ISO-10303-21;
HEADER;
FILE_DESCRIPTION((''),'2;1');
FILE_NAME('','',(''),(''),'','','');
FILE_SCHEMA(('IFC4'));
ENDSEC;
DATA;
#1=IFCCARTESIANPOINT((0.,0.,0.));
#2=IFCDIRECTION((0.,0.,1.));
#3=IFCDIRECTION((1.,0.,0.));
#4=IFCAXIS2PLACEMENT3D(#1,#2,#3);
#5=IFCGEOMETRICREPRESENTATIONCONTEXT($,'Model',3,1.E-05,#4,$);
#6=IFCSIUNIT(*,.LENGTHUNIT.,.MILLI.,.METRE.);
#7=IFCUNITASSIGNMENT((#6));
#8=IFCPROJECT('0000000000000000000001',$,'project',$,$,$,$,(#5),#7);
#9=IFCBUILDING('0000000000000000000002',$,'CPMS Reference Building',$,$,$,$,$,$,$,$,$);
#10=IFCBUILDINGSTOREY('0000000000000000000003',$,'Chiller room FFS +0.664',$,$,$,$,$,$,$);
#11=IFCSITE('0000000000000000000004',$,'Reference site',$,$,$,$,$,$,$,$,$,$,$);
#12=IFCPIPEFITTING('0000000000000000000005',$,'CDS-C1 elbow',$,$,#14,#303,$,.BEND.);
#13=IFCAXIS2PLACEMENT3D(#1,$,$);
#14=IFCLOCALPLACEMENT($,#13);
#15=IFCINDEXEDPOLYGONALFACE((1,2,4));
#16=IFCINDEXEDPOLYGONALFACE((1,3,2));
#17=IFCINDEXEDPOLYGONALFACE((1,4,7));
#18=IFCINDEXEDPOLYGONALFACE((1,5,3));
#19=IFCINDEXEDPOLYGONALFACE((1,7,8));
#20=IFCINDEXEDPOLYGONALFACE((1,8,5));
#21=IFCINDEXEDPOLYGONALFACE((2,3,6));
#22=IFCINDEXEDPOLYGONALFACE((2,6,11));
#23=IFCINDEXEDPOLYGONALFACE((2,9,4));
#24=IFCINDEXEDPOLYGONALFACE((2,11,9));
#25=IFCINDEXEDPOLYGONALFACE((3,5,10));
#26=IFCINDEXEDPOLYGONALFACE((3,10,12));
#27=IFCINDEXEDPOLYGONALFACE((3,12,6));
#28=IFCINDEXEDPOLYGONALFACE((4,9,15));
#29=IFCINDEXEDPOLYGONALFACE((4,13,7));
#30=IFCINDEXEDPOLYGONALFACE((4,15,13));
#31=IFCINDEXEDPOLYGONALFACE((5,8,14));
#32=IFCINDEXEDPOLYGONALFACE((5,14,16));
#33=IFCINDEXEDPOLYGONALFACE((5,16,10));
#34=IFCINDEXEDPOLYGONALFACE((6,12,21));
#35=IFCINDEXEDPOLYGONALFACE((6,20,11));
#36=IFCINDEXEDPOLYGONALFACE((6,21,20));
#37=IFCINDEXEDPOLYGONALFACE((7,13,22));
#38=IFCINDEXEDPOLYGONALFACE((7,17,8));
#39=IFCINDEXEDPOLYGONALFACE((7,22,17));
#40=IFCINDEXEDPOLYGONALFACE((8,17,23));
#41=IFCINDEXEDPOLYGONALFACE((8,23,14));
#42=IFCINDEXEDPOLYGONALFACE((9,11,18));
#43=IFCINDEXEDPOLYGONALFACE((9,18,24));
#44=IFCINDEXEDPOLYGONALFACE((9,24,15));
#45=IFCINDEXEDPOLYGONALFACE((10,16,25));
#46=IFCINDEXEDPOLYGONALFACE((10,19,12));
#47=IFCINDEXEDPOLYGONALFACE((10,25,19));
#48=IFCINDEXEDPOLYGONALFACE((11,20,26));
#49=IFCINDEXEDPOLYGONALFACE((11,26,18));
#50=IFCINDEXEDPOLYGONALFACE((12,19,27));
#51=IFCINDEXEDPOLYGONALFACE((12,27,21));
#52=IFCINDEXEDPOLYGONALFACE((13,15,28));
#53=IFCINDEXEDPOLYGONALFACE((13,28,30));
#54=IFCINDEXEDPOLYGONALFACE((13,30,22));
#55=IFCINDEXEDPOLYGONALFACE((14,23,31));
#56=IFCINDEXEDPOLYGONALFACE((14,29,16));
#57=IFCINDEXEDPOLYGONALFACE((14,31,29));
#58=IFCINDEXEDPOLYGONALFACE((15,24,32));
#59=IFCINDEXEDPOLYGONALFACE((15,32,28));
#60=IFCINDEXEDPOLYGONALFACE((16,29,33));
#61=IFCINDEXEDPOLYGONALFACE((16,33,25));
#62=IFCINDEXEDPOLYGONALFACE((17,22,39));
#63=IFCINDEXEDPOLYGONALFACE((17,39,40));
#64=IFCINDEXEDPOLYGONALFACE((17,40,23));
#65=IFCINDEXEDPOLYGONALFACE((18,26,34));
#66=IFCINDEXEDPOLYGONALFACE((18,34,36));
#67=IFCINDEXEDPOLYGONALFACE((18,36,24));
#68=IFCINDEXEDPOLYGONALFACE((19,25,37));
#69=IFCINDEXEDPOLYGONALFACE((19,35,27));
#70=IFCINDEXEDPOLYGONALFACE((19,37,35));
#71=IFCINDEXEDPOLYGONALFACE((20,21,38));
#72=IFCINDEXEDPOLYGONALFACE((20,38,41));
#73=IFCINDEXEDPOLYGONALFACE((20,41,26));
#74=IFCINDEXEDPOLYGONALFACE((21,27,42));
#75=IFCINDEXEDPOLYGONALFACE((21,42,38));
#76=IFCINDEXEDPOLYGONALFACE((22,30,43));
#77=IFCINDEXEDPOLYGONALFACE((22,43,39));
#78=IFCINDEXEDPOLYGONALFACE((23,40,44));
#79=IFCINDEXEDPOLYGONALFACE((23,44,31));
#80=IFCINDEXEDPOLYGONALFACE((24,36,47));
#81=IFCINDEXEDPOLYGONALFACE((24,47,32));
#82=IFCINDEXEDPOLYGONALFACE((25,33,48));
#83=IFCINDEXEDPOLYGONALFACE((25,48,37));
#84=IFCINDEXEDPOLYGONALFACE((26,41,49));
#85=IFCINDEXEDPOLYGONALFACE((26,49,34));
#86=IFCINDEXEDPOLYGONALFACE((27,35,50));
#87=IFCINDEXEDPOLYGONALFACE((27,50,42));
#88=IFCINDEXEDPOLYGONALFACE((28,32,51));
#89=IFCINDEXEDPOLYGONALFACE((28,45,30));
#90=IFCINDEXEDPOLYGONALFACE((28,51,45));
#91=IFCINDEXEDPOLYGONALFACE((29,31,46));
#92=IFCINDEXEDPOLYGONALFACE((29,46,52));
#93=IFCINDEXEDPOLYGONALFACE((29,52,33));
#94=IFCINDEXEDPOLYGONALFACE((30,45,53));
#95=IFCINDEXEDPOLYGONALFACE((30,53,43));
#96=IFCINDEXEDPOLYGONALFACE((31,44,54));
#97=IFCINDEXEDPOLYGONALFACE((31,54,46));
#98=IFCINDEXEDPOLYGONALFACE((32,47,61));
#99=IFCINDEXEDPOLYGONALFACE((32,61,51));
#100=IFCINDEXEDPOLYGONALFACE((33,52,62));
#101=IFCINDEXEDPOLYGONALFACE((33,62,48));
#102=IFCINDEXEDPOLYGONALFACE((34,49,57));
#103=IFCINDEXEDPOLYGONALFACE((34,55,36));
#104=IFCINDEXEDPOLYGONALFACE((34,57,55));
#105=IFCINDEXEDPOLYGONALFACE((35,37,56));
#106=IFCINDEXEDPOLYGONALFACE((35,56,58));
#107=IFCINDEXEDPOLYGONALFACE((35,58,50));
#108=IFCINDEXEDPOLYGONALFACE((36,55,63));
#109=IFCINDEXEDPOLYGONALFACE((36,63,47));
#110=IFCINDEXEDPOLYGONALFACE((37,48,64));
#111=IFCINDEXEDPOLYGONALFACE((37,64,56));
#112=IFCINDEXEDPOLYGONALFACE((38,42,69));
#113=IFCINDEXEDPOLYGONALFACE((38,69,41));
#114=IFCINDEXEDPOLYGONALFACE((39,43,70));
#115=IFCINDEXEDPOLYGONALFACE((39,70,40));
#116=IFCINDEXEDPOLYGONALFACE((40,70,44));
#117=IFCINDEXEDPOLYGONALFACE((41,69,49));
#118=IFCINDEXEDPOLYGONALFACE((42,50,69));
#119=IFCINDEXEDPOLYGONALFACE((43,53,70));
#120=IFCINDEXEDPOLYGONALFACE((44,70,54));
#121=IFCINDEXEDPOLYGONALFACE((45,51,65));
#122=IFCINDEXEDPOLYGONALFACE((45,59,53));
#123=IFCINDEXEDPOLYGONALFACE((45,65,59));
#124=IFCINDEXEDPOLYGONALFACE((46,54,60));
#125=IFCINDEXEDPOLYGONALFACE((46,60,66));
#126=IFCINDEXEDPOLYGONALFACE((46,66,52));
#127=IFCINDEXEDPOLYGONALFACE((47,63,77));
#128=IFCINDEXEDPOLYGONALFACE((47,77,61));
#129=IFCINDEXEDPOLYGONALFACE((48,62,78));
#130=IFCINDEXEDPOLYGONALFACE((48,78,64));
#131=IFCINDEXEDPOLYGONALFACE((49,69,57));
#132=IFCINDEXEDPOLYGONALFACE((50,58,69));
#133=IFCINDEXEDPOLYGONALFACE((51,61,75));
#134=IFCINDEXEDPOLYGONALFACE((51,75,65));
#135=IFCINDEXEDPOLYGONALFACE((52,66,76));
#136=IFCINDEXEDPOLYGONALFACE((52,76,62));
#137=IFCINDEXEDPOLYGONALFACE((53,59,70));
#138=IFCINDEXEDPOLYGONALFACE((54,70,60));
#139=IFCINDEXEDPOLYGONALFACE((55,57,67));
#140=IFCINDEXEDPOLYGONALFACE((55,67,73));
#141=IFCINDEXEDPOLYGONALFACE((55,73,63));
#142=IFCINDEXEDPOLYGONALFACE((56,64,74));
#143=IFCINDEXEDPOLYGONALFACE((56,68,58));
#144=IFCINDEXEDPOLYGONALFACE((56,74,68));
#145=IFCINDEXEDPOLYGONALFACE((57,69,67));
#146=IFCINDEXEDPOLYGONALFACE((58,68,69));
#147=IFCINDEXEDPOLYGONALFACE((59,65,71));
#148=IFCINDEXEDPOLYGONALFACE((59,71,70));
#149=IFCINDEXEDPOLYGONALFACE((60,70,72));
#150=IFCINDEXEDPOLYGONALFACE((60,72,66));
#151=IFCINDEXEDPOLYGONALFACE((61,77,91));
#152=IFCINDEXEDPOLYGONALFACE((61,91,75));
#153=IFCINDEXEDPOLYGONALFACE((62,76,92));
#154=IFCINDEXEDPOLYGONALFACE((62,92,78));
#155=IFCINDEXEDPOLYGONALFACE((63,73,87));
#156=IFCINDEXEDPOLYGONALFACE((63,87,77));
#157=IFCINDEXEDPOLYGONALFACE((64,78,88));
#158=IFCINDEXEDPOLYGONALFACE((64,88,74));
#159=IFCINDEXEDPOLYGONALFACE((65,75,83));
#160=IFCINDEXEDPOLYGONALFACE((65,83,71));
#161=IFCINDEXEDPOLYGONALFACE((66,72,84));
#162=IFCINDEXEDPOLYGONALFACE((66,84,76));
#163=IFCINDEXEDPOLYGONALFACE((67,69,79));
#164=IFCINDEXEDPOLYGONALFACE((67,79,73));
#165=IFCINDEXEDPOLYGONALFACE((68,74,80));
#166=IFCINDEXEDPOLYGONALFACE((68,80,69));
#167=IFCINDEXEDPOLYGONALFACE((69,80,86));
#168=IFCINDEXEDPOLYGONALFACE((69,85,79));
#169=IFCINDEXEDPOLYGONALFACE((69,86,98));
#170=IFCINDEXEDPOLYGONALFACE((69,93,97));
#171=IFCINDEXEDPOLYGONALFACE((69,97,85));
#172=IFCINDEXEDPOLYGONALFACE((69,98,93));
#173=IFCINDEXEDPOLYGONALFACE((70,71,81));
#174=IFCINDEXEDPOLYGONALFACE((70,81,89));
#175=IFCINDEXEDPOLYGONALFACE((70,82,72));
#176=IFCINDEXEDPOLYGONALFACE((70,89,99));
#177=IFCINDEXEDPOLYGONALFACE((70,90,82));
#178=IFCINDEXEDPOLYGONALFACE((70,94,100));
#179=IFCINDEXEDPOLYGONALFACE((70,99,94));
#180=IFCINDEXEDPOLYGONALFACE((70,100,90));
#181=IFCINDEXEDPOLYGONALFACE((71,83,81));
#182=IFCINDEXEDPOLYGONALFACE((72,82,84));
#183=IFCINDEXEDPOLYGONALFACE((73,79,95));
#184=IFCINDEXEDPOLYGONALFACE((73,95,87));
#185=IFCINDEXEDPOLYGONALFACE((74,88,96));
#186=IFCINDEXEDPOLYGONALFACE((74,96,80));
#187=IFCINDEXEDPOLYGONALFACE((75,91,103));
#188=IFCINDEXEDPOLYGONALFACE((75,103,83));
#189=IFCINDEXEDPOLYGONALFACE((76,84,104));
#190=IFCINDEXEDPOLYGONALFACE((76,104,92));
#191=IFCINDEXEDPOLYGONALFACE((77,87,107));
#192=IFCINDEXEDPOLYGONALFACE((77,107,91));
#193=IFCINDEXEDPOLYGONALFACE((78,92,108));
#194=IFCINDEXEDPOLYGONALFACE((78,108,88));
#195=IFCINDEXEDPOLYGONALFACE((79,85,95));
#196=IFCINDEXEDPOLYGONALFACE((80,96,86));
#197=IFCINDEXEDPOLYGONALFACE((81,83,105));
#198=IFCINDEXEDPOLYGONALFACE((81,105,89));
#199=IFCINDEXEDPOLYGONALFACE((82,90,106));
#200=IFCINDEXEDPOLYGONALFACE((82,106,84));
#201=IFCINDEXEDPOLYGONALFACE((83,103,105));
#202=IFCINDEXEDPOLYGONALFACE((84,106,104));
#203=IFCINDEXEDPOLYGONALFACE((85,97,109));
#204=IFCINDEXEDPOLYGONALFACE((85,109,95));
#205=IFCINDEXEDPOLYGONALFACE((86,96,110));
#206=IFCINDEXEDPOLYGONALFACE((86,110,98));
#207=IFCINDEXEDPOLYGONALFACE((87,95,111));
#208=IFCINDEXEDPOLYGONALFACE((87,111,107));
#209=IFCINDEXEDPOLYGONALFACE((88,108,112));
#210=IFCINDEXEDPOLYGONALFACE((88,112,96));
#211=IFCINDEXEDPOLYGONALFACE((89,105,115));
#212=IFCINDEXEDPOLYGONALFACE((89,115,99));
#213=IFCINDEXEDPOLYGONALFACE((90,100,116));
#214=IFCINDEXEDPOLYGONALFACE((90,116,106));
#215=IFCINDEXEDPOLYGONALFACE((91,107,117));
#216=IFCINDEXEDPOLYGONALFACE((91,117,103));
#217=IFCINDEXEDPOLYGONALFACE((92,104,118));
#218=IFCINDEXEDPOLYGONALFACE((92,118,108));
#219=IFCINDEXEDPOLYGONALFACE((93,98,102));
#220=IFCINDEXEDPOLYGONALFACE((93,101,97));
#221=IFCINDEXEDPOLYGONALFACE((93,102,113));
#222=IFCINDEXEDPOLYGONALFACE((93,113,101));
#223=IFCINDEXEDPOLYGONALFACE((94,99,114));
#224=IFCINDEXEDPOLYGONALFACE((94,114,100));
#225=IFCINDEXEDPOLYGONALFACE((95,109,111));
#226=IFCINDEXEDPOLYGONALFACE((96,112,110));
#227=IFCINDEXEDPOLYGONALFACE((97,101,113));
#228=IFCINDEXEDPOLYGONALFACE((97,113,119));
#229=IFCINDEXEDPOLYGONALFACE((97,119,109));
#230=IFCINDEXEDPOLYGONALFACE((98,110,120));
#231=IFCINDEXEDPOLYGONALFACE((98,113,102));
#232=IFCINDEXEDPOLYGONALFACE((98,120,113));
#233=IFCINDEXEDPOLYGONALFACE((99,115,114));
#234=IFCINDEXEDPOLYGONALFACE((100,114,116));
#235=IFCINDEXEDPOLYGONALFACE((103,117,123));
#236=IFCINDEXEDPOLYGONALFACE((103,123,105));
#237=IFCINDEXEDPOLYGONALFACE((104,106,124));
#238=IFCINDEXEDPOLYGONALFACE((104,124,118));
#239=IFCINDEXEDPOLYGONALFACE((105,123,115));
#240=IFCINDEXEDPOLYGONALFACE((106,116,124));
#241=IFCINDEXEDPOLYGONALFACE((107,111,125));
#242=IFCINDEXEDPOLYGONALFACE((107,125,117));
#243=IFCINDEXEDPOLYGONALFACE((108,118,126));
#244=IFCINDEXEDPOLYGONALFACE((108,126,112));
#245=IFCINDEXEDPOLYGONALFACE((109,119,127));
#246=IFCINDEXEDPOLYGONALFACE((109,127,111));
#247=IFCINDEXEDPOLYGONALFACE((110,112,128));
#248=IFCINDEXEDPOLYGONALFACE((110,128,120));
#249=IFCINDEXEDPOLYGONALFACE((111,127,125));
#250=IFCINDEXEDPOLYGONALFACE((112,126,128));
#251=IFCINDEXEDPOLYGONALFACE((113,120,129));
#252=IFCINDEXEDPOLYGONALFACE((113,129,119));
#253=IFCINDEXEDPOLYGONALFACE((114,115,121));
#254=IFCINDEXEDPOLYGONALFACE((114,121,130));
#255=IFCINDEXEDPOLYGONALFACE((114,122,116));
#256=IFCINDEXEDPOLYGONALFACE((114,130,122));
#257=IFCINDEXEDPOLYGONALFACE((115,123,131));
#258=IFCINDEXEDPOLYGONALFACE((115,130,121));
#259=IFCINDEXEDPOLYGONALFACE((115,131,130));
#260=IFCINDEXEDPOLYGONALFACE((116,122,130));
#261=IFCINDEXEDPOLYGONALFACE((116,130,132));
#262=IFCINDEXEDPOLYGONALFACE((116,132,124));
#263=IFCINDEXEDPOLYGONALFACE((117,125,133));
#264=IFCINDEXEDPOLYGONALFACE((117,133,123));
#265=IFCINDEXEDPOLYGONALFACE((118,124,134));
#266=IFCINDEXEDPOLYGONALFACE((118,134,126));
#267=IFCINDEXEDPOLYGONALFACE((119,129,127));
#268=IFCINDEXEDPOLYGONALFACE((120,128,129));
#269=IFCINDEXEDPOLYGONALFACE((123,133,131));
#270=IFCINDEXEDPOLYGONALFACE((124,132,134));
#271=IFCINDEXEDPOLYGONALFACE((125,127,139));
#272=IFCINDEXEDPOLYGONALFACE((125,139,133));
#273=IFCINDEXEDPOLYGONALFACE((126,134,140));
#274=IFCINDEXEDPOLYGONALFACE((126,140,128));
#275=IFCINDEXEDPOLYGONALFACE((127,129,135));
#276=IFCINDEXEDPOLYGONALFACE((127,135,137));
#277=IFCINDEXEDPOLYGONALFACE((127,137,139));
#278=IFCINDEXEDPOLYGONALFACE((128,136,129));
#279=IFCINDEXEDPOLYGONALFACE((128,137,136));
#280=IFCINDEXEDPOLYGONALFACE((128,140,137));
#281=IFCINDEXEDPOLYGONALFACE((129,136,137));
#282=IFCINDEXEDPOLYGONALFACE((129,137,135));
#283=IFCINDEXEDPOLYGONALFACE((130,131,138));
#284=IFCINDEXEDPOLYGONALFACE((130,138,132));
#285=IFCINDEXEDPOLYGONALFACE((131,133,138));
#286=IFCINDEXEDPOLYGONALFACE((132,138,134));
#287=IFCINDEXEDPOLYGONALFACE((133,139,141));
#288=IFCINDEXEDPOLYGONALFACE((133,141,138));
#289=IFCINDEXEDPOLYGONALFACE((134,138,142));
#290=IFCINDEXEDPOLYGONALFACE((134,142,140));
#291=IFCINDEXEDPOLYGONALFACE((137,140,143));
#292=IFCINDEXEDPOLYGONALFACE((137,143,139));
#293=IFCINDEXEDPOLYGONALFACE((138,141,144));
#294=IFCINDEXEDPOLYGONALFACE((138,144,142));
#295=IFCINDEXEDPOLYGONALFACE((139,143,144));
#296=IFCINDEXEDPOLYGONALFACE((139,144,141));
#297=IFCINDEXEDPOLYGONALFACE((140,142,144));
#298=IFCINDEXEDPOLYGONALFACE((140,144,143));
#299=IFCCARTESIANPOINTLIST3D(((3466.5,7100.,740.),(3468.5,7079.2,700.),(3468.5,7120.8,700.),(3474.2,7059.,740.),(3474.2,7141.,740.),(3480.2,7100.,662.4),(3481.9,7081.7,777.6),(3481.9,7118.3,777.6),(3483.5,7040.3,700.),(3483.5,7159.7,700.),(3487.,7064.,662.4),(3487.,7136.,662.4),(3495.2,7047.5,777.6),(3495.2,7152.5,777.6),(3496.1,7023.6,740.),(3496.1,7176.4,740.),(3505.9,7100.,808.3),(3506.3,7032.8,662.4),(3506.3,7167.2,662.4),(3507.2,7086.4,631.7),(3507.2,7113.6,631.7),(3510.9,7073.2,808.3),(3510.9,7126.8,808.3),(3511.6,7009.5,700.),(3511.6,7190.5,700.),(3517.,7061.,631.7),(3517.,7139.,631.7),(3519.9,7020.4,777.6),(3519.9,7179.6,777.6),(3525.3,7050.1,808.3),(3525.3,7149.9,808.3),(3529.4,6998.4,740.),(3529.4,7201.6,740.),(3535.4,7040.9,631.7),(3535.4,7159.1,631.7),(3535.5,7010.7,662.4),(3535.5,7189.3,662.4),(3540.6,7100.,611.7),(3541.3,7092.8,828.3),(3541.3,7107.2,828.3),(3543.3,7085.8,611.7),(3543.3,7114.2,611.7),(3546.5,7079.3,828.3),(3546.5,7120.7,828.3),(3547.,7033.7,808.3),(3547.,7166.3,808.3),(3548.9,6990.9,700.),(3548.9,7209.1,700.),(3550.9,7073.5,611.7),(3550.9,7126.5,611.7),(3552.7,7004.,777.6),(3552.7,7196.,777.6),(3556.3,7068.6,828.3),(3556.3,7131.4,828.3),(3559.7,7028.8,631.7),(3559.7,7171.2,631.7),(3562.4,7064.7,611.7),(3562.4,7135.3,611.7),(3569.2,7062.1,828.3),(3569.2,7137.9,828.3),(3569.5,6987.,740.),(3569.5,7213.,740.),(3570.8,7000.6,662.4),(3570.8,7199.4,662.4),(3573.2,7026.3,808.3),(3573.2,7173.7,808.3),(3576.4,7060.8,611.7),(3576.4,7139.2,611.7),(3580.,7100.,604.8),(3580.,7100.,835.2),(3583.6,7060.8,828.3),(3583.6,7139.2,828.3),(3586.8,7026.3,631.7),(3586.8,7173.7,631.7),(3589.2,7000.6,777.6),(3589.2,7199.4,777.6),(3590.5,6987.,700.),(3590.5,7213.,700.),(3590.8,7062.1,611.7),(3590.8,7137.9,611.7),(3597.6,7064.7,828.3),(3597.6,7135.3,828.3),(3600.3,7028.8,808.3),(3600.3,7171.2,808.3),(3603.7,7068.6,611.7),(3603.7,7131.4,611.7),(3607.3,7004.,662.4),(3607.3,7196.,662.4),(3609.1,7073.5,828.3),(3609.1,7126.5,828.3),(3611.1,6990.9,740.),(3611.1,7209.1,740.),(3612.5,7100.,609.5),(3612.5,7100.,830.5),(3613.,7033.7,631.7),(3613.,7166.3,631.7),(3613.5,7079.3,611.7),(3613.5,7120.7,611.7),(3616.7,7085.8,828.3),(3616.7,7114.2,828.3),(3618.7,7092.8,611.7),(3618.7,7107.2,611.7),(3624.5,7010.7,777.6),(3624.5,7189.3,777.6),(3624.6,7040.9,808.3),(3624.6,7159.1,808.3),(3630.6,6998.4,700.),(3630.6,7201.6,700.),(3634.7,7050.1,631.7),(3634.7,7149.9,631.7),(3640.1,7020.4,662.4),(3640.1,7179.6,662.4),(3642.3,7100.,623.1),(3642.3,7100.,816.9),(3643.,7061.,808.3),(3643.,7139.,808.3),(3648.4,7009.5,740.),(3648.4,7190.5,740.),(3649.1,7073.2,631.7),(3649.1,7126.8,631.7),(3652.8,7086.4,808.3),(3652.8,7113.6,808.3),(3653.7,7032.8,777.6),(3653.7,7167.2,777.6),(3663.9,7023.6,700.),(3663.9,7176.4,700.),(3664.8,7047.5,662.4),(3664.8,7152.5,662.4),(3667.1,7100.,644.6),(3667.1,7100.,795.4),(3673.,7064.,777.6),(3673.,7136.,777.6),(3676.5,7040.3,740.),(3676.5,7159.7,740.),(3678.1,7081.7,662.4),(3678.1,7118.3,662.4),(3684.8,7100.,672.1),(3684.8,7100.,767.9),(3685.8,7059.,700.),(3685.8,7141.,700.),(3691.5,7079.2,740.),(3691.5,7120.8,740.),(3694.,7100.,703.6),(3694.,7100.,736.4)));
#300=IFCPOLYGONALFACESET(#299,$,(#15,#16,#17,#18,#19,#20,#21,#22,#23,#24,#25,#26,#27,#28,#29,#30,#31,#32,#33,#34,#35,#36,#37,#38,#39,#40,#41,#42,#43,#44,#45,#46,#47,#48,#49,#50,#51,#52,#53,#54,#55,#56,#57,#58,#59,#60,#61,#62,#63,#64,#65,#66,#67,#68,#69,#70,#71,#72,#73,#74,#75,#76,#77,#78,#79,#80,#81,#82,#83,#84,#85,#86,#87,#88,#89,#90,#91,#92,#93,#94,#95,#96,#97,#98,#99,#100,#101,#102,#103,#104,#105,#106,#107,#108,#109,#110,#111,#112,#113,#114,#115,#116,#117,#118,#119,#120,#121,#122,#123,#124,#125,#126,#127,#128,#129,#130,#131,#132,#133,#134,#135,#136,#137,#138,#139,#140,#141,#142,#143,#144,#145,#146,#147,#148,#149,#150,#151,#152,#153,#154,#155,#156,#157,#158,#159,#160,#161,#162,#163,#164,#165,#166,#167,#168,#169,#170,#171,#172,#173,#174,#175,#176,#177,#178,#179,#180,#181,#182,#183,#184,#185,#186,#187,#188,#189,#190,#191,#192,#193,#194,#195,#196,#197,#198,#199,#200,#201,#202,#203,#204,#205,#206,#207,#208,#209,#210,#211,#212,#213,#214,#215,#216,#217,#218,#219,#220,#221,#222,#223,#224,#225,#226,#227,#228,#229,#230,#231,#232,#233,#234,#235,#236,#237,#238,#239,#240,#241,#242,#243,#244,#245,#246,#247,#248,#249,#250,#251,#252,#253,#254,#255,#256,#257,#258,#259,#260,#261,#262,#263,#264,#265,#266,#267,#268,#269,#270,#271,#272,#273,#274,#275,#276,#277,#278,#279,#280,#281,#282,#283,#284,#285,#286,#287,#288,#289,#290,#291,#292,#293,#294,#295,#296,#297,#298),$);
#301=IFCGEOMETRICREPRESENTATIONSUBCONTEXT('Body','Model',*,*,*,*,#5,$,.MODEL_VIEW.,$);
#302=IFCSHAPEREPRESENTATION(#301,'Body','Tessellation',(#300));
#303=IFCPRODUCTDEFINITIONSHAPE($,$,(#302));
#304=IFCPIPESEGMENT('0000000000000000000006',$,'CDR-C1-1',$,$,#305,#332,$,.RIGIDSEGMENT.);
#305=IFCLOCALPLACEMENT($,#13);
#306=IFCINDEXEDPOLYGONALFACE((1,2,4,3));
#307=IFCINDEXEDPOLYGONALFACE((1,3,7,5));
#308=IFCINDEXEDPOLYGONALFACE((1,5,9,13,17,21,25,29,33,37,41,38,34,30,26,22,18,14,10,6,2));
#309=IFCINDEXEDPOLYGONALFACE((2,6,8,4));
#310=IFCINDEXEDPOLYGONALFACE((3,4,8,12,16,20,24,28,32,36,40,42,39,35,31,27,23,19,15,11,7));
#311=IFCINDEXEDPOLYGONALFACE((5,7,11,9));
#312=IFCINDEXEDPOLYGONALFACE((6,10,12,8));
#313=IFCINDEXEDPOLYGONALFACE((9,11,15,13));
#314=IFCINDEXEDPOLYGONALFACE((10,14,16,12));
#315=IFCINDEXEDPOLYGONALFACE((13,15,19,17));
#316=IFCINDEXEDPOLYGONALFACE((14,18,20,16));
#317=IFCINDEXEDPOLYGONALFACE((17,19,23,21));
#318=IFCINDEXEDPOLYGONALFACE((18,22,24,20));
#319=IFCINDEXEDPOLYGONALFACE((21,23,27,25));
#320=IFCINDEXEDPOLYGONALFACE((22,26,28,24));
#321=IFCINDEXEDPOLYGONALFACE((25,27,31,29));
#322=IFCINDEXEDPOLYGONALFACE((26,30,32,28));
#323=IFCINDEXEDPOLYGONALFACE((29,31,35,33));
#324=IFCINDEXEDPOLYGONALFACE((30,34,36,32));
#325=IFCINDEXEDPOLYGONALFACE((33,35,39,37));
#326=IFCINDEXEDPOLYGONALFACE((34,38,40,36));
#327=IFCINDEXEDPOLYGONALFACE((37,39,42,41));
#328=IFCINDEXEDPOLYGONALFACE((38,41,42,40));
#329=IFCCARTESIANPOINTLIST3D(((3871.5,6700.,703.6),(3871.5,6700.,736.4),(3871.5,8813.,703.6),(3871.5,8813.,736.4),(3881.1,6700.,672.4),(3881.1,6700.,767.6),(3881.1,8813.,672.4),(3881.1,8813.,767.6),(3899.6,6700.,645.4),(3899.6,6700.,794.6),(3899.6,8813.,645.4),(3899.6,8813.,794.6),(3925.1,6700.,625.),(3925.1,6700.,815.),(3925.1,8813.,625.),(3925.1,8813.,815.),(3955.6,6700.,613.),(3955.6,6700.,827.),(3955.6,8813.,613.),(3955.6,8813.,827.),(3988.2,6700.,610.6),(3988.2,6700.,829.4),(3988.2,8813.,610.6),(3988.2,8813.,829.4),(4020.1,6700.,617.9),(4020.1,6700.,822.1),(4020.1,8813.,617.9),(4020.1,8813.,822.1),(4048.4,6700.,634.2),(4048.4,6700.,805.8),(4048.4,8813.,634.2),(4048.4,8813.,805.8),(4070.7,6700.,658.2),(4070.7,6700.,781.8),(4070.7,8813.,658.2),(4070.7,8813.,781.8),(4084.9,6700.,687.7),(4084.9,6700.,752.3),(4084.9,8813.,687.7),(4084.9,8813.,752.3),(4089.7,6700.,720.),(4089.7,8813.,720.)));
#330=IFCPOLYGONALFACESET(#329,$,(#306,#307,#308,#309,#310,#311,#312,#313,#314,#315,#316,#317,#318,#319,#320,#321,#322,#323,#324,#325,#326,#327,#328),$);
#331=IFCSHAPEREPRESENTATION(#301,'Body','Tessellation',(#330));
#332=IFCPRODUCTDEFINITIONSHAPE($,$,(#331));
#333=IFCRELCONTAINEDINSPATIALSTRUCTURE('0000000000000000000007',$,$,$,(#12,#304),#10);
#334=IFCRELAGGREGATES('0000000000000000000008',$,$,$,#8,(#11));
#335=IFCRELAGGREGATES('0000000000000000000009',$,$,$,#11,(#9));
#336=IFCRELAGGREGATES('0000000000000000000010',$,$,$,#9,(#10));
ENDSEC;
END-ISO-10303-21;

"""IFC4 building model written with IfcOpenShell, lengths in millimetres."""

from ifc_helpers import new_model, entity, si_unit, frame, origin_with_axes, origin_2d, place, context, subcontext, project, spatial, circle_curve, outline, extrude, element, save


model = new_model("IFC4")

# Units and contexts
model_context = context("Model", 3, precision=1e-05, world=origin_with_axes())
body_context = subcontext(model_context, "Body", "Model", "MODEL_VIEW")
ifc_project = project(units=[si_unit("LENGTHUNIT", "METRE", prefix="MILLI")], contexts=[model_context])

# Site, building, storey
site = spatial("IfcSite", under=ifc_project, Name="Reference site")
building = spatial("IfcBuilding", under=site, Name="CPMS Reference Building")
storey = spatial("IfcBuildingStorey", under=building, Name="Chiller room FFS +0.664")

# Pipe fitting
pipe_fitting_1_placement = place(None, origin_with_axes())
element("IfcPipeFitting", 1, at=pipe_fitting_1_placement, inside=storey, Name="CDS-C1 elbow", PredefinedType="BEND", context=body_context, shape_type="CSG", body=[
    entity("IfcSphere", entity("IfcAxis2Placement3D", entity("IfcCartesianPoint", [3580.0, 7100.0, 720.0]), entity("IfcDirection", [0.0, 0.0, 1.0]), entity("IfcDirection", [1.0, 0.0, 0.0])), 115.2),
])

# Pipe segment
pipe_segment_1_placement = place(None, origin_with_axes())
element("IfcPipeSegment", 2, at=pipe_segment_1_placement, inside=storey, Name="CDR-C1-1", PredefinedType="RIGIDSEGMENT", context=body_context, shape_type="SweptSolid", body=[
    extrude(outline(circle_curve(origin_2d(), 109.7)), frame((3980.0, 8813.0, 720.0), z_axis=(0.0, -1.0, 0.0), x_axis=(1.0, 0.0, 0.0)), (0.0, 0.0, 1.0), 2113.0),
])

save(model, "model.ifc")
